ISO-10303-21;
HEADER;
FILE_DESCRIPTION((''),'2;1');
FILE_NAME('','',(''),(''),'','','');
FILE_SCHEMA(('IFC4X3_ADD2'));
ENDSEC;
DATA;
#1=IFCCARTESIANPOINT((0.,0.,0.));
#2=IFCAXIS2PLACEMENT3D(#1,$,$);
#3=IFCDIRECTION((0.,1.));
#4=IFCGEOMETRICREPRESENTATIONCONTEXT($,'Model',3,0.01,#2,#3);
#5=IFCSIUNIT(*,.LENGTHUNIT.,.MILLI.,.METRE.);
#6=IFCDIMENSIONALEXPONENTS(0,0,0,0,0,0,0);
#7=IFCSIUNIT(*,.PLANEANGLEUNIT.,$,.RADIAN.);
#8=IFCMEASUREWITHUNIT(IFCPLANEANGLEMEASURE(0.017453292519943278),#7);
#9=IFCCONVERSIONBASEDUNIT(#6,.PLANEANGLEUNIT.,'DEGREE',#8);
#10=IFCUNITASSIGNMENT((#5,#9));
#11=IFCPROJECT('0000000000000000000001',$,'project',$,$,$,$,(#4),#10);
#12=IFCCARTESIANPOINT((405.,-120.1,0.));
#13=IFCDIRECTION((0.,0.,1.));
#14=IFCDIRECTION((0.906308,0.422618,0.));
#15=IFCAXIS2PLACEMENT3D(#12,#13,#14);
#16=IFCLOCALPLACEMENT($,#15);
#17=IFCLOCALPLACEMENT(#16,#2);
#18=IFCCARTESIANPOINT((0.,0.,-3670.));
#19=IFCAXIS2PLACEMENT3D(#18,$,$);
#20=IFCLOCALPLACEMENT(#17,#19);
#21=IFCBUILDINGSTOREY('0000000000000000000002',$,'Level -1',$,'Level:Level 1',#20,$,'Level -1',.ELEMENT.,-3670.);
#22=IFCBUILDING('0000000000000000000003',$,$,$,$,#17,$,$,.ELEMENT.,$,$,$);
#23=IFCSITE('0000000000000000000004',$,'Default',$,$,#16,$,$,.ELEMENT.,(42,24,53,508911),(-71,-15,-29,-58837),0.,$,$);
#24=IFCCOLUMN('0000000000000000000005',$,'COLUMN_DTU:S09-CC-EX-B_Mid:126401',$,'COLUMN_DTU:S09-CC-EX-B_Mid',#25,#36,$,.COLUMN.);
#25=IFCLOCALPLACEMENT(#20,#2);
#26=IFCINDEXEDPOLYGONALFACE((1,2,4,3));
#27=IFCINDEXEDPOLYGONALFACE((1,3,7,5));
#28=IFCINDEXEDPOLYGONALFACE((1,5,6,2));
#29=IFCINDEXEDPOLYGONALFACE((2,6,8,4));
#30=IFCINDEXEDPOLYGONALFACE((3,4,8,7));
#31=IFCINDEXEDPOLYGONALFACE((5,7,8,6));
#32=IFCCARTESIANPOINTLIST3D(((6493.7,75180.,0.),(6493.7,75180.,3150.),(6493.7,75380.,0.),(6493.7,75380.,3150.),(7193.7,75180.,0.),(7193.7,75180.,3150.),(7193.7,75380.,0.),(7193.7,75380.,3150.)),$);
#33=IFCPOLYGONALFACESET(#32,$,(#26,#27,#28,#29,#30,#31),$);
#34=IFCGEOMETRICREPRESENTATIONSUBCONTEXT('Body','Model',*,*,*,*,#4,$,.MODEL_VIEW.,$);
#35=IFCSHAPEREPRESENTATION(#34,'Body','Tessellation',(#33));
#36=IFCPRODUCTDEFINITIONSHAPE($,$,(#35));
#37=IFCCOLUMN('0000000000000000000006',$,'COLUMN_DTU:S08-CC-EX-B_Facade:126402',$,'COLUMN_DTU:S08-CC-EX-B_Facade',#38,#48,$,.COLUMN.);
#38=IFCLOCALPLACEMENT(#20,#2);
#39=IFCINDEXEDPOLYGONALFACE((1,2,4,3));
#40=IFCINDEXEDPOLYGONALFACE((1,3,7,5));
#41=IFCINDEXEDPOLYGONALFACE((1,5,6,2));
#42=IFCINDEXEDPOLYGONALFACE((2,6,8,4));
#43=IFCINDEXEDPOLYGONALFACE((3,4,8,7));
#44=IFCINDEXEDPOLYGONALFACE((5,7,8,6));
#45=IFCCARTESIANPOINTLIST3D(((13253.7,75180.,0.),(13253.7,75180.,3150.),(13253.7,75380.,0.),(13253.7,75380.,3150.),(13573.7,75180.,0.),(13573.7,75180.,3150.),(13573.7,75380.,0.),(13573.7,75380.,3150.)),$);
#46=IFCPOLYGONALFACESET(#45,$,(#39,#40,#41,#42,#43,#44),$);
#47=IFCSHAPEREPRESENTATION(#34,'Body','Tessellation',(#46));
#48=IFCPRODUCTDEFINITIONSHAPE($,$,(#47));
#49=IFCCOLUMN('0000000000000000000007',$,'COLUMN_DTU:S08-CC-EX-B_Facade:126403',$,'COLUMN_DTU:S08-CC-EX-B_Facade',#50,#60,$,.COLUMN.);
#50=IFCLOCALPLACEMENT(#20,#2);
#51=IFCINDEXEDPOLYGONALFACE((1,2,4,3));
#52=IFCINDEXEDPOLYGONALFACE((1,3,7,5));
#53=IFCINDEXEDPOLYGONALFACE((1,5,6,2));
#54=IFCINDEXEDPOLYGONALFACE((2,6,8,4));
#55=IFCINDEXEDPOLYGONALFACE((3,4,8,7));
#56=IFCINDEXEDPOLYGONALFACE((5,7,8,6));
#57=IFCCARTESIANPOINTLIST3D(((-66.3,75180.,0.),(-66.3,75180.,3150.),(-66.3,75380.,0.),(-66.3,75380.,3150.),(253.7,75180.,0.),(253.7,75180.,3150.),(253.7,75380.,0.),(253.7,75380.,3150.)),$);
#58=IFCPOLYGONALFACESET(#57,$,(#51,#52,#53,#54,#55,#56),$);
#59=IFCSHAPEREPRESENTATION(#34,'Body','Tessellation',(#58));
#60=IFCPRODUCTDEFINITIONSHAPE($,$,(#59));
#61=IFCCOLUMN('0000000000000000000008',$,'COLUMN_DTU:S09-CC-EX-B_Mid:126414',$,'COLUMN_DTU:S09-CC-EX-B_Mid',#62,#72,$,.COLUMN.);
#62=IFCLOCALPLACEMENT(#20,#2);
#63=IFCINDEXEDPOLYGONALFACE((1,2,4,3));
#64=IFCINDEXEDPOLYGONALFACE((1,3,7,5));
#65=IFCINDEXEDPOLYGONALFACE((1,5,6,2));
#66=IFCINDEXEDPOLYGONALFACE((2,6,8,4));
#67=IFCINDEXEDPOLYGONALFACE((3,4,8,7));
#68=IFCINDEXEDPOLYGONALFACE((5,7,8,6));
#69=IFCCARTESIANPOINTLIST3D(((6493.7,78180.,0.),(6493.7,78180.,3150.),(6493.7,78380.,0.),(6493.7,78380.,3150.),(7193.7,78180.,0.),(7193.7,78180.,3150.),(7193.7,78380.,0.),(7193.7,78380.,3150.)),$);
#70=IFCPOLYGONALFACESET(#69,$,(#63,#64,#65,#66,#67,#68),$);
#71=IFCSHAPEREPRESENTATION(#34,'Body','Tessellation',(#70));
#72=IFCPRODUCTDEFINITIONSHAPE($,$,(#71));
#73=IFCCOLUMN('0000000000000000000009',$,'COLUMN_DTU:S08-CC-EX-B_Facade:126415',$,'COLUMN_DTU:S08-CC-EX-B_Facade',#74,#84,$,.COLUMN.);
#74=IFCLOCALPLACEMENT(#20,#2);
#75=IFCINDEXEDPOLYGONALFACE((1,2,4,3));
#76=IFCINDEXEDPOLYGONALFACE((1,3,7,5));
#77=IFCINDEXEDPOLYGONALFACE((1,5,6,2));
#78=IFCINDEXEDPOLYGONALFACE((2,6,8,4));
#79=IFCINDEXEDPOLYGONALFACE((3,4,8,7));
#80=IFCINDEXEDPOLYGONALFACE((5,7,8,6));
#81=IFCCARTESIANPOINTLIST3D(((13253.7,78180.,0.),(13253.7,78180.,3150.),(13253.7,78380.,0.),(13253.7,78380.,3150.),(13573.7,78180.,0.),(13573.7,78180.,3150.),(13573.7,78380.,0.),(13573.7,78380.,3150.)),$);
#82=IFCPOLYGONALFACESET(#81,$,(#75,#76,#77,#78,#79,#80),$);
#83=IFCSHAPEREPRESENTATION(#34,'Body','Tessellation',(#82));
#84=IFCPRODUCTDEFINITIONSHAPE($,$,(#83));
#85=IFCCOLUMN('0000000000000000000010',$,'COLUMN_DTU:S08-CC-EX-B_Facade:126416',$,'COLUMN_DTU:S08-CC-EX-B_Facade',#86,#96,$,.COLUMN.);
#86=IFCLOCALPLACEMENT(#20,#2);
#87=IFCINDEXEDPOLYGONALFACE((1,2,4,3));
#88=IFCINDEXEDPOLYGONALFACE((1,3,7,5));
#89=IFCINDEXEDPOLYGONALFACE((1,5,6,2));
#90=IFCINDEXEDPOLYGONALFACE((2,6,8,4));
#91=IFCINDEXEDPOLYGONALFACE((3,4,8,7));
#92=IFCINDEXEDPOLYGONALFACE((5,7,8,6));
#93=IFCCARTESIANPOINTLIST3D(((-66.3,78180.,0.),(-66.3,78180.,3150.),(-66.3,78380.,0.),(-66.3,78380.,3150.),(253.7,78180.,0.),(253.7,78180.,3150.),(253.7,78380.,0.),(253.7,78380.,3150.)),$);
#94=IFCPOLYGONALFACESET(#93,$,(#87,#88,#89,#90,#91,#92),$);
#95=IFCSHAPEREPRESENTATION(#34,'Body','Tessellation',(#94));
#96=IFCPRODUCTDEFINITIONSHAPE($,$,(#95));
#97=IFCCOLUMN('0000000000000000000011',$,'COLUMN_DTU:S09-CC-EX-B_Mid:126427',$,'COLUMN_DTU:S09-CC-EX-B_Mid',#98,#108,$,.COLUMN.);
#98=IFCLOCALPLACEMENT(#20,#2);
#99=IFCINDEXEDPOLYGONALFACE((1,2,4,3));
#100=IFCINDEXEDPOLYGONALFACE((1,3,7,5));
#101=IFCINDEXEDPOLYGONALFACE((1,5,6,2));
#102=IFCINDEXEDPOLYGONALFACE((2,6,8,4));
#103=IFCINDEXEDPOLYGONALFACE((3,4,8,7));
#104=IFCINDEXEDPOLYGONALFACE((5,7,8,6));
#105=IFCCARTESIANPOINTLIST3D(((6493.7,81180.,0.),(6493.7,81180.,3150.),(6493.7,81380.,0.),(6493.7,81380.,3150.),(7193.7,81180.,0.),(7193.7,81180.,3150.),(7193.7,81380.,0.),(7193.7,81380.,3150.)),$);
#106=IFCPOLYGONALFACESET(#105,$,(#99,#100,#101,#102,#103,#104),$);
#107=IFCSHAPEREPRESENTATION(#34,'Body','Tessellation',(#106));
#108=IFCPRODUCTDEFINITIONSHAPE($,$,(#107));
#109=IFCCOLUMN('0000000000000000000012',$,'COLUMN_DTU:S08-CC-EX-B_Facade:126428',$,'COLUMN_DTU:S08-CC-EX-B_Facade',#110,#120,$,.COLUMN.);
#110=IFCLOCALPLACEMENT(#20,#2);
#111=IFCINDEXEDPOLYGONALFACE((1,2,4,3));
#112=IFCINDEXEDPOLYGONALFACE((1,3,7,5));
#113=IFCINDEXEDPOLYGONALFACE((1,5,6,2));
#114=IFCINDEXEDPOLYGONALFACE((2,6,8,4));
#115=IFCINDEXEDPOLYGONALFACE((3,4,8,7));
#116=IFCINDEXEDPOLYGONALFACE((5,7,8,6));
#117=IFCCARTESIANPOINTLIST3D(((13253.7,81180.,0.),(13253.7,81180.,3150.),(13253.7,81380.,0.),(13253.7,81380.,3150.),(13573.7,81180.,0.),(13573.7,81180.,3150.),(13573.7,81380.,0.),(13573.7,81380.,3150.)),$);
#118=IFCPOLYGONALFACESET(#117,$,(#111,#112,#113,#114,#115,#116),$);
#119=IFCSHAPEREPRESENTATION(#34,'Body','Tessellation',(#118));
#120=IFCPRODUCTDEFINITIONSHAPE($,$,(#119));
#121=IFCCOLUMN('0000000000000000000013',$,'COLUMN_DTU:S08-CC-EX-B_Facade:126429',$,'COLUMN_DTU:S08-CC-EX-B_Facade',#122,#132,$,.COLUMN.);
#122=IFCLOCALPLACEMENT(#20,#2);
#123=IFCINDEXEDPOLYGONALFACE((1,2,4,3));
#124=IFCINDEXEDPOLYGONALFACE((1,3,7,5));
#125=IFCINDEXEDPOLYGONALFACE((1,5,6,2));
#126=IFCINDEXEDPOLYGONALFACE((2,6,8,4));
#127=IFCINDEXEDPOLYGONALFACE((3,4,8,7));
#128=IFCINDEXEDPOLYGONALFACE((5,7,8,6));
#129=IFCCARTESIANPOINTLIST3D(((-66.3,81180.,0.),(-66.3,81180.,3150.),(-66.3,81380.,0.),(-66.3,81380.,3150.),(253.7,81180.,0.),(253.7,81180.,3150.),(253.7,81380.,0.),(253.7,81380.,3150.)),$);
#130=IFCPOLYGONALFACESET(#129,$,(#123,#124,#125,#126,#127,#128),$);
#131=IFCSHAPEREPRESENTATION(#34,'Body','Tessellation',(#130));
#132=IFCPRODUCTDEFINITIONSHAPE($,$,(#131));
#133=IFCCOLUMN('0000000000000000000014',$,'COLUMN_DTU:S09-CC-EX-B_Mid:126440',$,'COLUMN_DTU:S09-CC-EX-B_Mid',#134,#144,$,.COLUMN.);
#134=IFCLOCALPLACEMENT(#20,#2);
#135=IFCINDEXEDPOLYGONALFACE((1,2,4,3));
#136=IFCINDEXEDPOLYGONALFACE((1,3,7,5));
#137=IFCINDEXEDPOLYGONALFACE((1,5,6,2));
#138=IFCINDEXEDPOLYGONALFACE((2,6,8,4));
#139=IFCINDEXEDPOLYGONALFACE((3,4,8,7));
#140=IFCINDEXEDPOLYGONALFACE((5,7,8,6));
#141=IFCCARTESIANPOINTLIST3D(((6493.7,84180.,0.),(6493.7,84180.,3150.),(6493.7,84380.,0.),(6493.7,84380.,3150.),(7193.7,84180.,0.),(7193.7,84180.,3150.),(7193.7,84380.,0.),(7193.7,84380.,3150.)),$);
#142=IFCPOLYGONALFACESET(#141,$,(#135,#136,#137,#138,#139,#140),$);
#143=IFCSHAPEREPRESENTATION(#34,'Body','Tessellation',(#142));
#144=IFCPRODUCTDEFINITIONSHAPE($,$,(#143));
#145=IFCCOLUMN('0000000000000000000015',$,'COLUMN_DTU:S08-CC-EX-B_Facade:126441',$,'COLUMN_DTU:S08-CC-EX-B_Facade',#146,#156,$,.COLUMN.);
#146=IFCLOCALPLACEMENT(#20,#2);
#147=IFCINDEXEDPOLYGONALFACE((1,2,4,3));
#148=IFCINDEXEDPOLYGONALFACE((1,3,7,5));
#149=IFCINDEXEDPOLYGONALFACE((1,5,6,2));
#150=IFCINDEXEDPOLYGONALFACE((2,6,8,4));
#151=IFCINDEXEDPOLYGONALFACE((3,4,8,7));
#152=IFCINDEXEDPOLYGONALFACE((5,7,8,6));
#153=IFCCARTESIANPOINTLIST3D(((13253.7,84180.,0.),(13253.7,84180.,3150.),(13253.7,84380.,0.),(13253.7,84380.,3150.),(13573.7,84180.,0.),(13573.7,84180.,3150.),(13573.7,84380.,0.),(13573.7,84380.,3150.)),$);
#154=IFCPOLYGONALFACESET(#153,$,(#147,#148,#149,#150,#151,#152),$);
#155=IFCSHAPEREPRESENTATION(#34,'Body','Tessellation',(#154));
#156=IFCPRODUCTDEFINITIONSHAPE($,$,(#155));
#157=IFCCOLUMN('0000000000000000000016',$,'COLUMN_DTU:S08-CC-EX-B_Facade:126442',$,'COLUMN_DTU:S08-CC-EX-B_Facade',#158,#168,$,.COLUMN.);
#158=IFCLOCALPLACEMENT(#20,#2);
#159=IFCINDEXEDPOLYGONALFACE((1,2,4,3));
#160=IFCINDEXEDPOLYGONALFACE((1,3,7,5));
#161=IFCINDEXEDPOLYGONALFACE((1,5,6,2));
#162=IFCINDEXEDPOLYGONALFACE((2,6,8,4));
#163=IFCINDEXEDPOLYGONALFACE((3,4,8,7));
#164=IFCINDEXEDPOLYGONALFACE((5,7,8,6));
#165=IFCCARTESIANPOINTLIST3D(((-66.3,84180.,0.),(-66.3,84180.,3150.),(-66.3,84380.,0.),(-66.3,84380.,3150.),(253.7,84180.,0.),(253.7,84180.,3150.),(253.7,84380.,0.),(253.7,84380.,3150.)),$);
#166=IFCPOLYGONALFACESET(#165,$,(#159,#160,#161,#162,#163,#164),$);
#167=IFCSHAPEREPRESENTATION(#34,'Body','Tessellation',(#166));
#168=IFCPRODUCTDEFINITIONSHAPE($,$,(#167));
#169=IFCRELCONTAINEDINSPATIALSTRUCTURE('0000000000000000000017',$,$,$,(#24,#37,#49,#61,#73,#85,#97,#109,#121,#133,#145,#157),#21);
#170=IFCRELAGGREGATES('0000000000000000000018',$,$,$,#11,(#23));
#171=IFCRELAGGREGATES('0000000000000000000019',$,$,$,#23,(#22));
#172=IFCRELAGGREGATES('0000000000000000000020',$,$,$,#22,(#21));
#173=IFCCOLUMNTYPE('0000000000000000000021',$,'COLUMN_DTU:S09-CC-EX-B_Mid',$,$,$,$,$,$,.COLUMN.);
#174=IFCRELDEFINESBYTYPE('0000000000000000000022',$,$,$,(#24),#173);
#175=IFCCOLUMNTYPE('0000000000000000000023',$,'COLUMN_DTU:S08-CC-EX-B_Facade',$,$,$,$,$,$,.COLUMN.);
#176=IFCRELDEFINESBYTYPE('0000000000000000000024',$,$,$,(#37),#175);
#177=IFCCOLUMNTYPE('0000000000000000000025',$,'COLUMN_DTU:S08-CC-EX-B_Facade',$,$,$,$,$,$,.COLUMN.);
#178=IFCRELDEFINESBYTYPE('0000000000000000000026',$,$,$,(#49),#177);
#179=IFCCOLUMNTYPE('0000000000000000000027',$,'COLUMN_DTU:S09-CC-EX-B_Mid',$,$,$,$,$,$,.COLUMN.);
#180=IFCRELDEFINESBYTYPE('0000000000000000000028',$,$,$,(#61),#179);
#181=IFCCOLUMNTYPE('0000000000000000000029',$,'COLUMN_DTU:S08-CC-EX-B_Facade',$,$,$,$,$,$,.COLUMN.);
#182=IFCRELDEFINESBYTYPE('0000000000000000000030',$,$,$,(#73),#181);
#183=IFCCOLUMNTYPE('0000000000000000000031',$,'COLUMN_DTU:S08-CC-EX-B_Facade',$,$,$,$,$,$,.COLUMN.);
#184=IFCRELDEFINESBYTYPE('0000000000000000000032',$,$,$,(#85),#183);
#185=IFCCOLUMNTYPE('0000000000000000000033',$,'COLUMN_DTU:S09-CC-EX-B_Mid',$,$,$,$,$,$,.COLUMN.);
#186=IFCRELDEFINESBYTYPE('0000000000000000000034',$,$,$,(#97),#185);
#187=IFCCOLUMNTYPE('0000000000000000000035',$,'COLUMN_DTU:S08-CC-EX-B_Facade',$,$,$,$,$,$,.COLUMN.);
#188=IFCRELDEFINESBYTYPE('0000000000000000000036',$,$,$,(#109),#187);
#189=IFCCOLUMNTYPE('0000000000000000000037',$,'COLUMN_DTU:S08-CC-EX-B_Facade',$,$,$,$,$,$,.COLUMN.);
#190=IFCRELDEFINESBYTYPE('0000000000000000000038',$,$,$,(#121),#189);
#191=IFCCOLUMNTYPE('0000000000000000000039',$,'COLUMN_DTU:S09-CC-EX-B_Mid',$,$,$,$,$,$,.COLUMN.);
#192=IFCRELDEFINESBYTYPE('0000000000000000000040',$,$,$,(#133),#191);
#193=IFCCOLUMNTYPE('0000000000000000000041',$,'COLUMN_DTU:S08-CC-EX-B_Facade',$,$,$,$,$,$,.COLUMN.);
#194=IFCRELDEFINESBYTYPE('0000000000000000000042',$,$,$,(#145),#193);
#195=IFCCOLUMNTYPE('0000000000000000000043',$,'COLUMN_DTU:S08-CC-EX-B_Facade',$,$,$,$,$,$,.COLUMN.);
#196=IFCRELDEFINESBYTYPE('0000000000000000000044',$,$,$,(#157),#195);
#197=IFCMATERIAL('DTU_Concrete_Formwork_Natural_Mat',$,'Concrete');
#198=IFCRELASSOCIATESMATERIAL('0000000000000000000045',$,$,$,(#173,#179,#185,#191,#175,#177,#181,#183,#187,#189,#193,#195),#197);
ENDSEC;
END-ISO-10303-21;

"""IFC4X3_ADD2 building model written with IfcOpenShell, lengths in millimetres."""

from ifc_helpers import new_model, entity, si_unit, converted_unit, direction, frame, frame_2d, origin, origin_2d_with_axis, place, context, subcontext, project, spatial, rectangle, extrude, source, transform, mapped, material, material_profile, profile_set, type_object, type_shapes, element, save


model = new_model("IFC4X3_ADD2")

# Units and contexts
model_context = context("Model", 3, precision=0.01, world=origin(), true_north=direction((0.0, 1.0)))
body_context = subcontext(model_context, "Body", "Model", "MODEL_VIEW")
ifc_project = project(units=[si_unit("LENGTHUNIT", "METRE", prefix="MILLI"), converted_unit("PLANEANGLEUNIT", "DEGREE", entity("IfcPlaneAngleMeasure", 0.017453292519943278), si_unit("PLANEANGLEUNIT", "RADIAN"), dimensions=[0, 0, 0, 0, 0, 0, 0])], contexts=[model_context])

# Site, building, storey
site_placement = place(None, frame((405.0, -120.1, 0.0), z_axis=(0.0, 0.0, 1.0), x_axis=(0.906308, 0.422618, 0.0)))
site = spatial("IfcSite", under=ifc_project, at=site_placement, Name="Default", CompositionType="ELEMENT", RefLatitude=(42, 24, 53, 508911), RefLongitude=(-71, -15, -29, -58837), RefElevation=0.0)
building_placement = place(site_placement, origin())
building = spatial("IfcBuilding", under=site, at=building_placement, CompositionType="ELEMENT")
storey_placement = place(building_placement, frame((0.0, 0.0, -3670.0)))
storey = spatial("IfcBuildingStorey", under=building, at=storey_placement, Name="Level -1", ObjectType="Level:Level 1", LongName="Level -1", CompositionType="ELEMENT", Elevation=-3670.0)

# Columns
ifc_material = material(Name="DTU_Concrete_Formwork_Natural_Mat", Category="Concrete")
ifc_material_profile_1 = material_profile(ifc_material, rectangle(XDim=200.0, YDim=700.0, at=frame_2d((0.0, 0.0), x_axis=(1.0, 0.0))), Name="S09-CC-EX-B_Mid")
ifc_profile_set_1 = profile_set([ifc_material_profile_1], Name="S09-CC-EX-B_Mid")
column_type_1 = type_object("IfcColumnType", Name="COLUMN_DTU:S09-CC-EX-B_Mid", PredefinedType="COLUMN", material=ifc_profile_set_1)
shared_shape_1 = source(origin(), body_context, "Body", "SweptSolid", [
    extrude(rectangle(XDim=200.0, YDim=700.0, at=frame_2d((0.0, 0.0), x_axis=(1.0, 0.0))), frame((6843.7, 75280.0, -3670.0), z_axis=(0.0, 0.0, 1.0), x_axis=(0.0, 1.0, 0.0)), (0.0, 0.0, 1.0), 3150.0),
])
type_shapes(column_type_1, [shared_shape_1])
column_1_placement = place(storey_placement, frame((0.0, 0.0, 3670.0)))
element("IfcColumn", 1, at=column_1_placement, inside=storey, type_object=column_type_1, Name="COLUMN_DTU:S09-CC-EX-B_Mid:126401", ObjectType="COLUMN_DTU:S09-CC-EX-B_Mid", PredefinedType="COLUMN", context=body_context, shape_type="MappedRepresentation", body=[
    mapped(shared_shape_1, transform((0.0, 0.0, 0.0), scale=1.0)),
])
ifc_material_profile_2 = material_profile(ifc_material, rectangle(XDim=200.0, YDim=320.0, at=origin_2d_with_axis()), Name="S08-CC-EX-B_Facade")
ifc_profile_set_2 = profile_set([ifc_material_profile_2], Name="S08-CC-EX-B_Facade")
column_type_2 = type_object("IfcColumnType", Name="COLUMN_DTU:S08-CC-EX-B_Facade", PredefinedType="COLUMN", material=ifc_profile_set_2)
shared_shape_2 = source(origin(), body_context, "Body", "SweptSolid", [
    extrude(rectangle(XDim=200.0, YDim=320.0, at=frame_2d((0.0, 0.0), x_axis=(1.0, 0.0))), frame((13413.7, 75280.0, -3670.0), z_axis=(0.0, 0.0, 1.0), x_axis=(0.0, 1.0, 0.0)), (0.0, 0.0, 1.0), 3150.0),
])
type_shapes(column_type_2, [shared_shape_2])
column_2_placement = place(storey_placement, frame((0.0, 0.0, 3670.0)))
element("IfcColumn", 2, at=column_2_placement, inside=storey, type_object=column_type_2, Name="COLUMN_DTU:S08-CC-EX-B_Facade:126402", ObjectType="COLUMN_DTU:S08-CC-EX-B_Facade", PredefinedType="COLUMN", context=body_context, shape_type="MappedRepresentation", body=[
    mapped(shared_shape_2, transform((0.0, 0.0, 0.0), scale=1.0)),
])
column_type_3 = type_object("IfcColumnType", Name="COLUMN_DTU:S08-CC-EX-B_Facade", PredefinedType="COLUMN", material=ifc_profile_set_2)
shared_shape_3 = source(origin(), body_context, "Body", "SweptSolid", [
    extrude(rectangle(XDim=200.0, YDim=320.0, at=frame_2d((0.0, 0.0), x_axis=(1.0, 0.0))), frame((93.7, 75280.0, -3670.0), z_axis=(0.0, 0.0, 1.0), x_axis=(0.0, -1.0, 0.0)), (0.0, 0.0, 1.0), 3150.0),
])
type_shapes(column_type_3, [shared_shape_3])
column_3_placement = place(storey_placement, frame((0.0, 0.0, 3670.0)))
element("IfcColumn", 3, at=column_3_placement, inside=storey, type_object=column_type_3, Name="COLUMN_DTU:S08-CC-EX-B_Facade:126403", ObjectType="COLUMN_DTU:S08-CC-EX-B_Facade", PredefinedType="COLUMN", context=body_context, shape_type="MappedRepresentation", body=[
    mapped(shared_shape_3, transform((0.0, 0.0, 0.0), scale=1.0)),
])
column_type_4 = type_object("IfcColumnType", Name="COLUMN_DTU:S09-CC-EX-B_Mid", PredefinedType="COLUMN", material=ifc_profile_set_1)
shared_shape_4 = source(origin(), body_context, "Body", "SweptSolid", [
    extrude(rectangle(XDim=200.0, YDim=700.0, at=frame_2d((0.0, 0.0), x_axis=(1.0, 0.0))), frame((6843.7, 78280.0, -3670.0), z_axis=(0.0, 0.0, 1.0), x_axis=(0.0, 1.0, 0.0)), (0.0, 0.0, 1.0), 3150.0),
])
type_shapes(column_type_4, [shared_shape_4])
column_4_placement = place(storey_placement, frame((0.0, 0.0, 3670.0)))
element("IfcColumn", 4, at=column_4_placement, inside=storey, type_object=column_type_4, Name="COLUMN_DTU:S09-CC-EX-B_Mid:126414", ObjectType="COLUMN_DTU:S09-CC-EX-B_Mid", PredefinedType="COLUMN", context=body_context, shape_type="MappedRepresentation", body=[
    mapped(shared_shape_4, transform((0.0, 0.0, 0.0), scale=1.0)),
])
column_type_5 = type_object("IfcColumnType", Name="COLUMN_DTU:S08-CC-EX-B_Facade", PredefinedType="COLUMN", material=ifc_profile_set_2)
shared_shape_5 = source(origin(), body_context, "Body", "SweptSolid", [
    extrude(rectangle(XDim=200.0, YDim=320.0, at=frame_2d((0.0, 0.0), x_axis=(1.0, 0.0))), frame((13413.7, 78280.0, -3670.0), z_axis=(0.0, 0.0, 1.0), x_axis=(0.0, 1.0, 0.0)), (0.0, 0.0, 1.0), 3150.0),
])
type_shapes(column_type_5, [shared_shape_5])
column_5_placement = place(storey_placement, frame((0.0, 0.0, 3670.0)))
element("IfcColumn", 5, at=column_5_placement, inside=storey, type_object=column_type_5, Name="COLUMN_DTU:S08-CC-EX-B_Facade:126415", ObjectType="COLUMN_DTU:S08-CC-EX-B_Facade", PredefinedType="COLUMN", context=body_context, shape_type="MappedRepresentation", body=[
    mapped(shared_shape_5, transform((0.0, 0.0, 0.0), scale=1.0)),
])
column_type_6 = type_object("IfcColumnType", Name="COLUMN_DTU:S08-CC-EX-B_Facade", PredefinedType="COLUMN", material=ifc_profile_set_2)
shared_shape_6 = source(origin(), body_context, "Body", "SweptSolid", [
    extrude(rectangle(XDim=200.0, YDim=320.0, at=frame_2d((0.0, 0.0), x_axis=(1.0, 0.0))), frame((93.7, 78280.0, -3670.0), z_axis=(0.0, 0.0, 1.0), x_axis=(0.0, -1.0, 0.0)), (0.0, 0.0, 1.0), 3150.0),
])
type_shapes(column_type_6, [shared_shape_6])
column_6_placement = place(storey_placement, frame((0.0, 0.0, 3670.0)))
element("IfcColumn", 6, at=column_6_placement, inside=storey, type_object=column_type_6, Name="COLUMN_DTU:S08-CC-EX-B_Facade:126416", ObjectType="COLUMN_DTU:S08-CC-EX-B_Facade", PredefinedType="COLUMN", context=body_context, shape_type="MappedRepresentation", body=[
    mapped(shared_shape_6, transform((0.0, 0.0, 0.0), scale=1.0)),
])
column_type_7 = type_object("IfcColumnType", Name="COLUMN_DTU:S09-CC-EX-B_Mid", PredefinedType="COLUMN", material=ifc_profile_set_1)
shared_shape_7 = source(origin(), body_context, "Body", "SweptSolid", [
    extrude(rectangle(XDim=200.0, YDim=700.0, at=frame_2d((0.0, 0.0), x_axis=(1.0, 0.0))), frame((6843.7, 81280.0, -3670.0), z_axis=(0.0, 0.0, 1.0), x_axis=(0.0, 1.0, 0.0)), (0.0, 0.0, 1.0), 3150.0),
])
type_shapes(column_type_7, [shared_shape_7])
column_7_placement = place(storey_placement, frame((0.0, 0.0, 3670.0)))
element("IfcColumn", 7, at=column_7_placement, inside=storey, type_object=column_type_7, Name="COLUMN_DTU:S09-CC-EX-B_Mid:126427", ObjectType="COLUMN_DTU:S09-CC-EX-B_Mid", PredefinedType="COLUMN", context=body_context, shape_type="MappedRepresentation", body=[
    mapped(shared_shape_7, transform((0.0, 0.0, 0.0), scale=1.0)),
])
column_type_8 = type_object("IfcColumnType", Name="COLUMN_DTU:S08-CC-EX-B_Facade", PredefinedType="COLUMN", material=ifc_profile_set_2)
shared_shape_8 = source(origin(), body_context, "Body", "SweptSolid", [
    extrude(rectangle(XDim=200.0, YDim=320.0, at=frame_2d((0.0, 0.0), x_axis=(1.0, 0.0))), frame((13413.7, 81280.0, -3670.0), z_axis=(0.0, 0.0, 1.0), x_axis=(0.0, 1.0, 0.0)), (0.0, 0.0, 1.0), 3150.0),
])
type_shapes(column_type_8, [shared_shape_8])
column_8_placement = place(storey_placement, frame((0.0, 0.0, 3670.0)))
element("IfcColumn", 8, at=column_8_placement, inside=storey, type_object=column_type_8, Name="COLUMN_DTU:S08-CC-EX-B_Facade:126428", ObjectType="COLUMN_DTU:S08-CC-EX-B_Facade", PredefinedType="COLUMN", context=body_context, shape_type="MappedRepresentation", body=[
    mapped(shared_shape_8, transform((0.0, 0.0, 0.0), scale=1.0)),
])
column_type_9 = type_object("IfcColumnType", Name="COLUMN_DTU:S08-CC-EX-B_Facade", PredefinedType="COLUMN", material=ifc_profile_set_2)
shared_shape_9 = source(origin(), body_context, "Body", "SweptSolid", [
    extrude(rectangle(XDim=200.0, YDim=320.0, at=frame_2d((0.0, 0.0), x_axis=(1.0, 0.0))), frame((93.7, 81280.0, -3670.0), z_axis=(0.0, 0.0, 1.0), x_axis=(0.0, -1.0, 0.0)), (0.0, 0.0, 1.0), 3150.0),
])
type_shapes(column_type_9, [shared_shape_9])
column_9_placement = place(storey_placement, frame((0.0, 0.0, 3670.0)))
element("IfcColumn", 9, at=column_9_placement, inside=storey, type_object=column_type_9, Name="COLUMN_DTU:S08-CC-EX-B_Facade:126429", ObjectType="COLUMN_DTU:S08-CC-EX-B_Facade", PredefinedType="COLUMN", context=body_context, shape_type="MappedRepresentation", body=[
    mapped(shared_shape_9, transform((0.0, 0.0, 0.0), scale=1.0)),
])
column_type_10 = type_object("IfcColumnType", Name="COLUMN_DTU:S09-CC-EX-B_Mid", PredefinedType="COLUMN", material=ifc_profile_set_1)
shared_shape_10 = source(origin(), body_context, "Body", "SweptSolid", [
    extrude(rectangle(XDim=200.0, YDim=700.0, at=frame_2d((0.0, 0.0), x_axis=(1.0, 0.0))), frame((6843.7, 84280.0, -3670.0), z_axis=(0.0, 0.0, 1.0), x_axis=(0.0, 1.0, 0.0)), (0.0, 0.0, 1.0), 3150.0),
])
type_shapes(column_type_10, [shared_shape_10])
column_10_placement = place(storey_placement, frame((0.0, 0.0, 3670.0)))
element("IfcColumn", 10, at=column_10_placement, inside=storey, type_object=column_type_10, Name="COLUMN_DTU:S09-CC-EX-B_Mid:126440", ObjectType="COLUMN_DTU:S09-CC-EX-B_Mid", PredefinedType="COLUMN", context=body_context, shape_type="MappedRepresentation", body=[
    mapped(shared_shape_10, transform((0.0, 0.0, 0.0), scale=1.0)),
])
column_type_11 = type_object("IfcColumnType", Name="COLUMN_DTU:S08-CC-EX-B_Facade", PredefinedType="COLUMN", material=ifc_profile_set_2)
shared_shape_11 = source(origin(), body_context, "Body", "SweptSolid", [
    extrude(rectangle(XDim=200.0, YDim=320.0, at=frame_2d((0.0, 0.0), x_axis=(1.0, 0.0))), frame((13413.7, 84280.0, -3670.0), z_axis=(0.0, 0.0, 1.0), x_axis=(0.0, 1.0, 0.0)), (0.0, 0.0, 1.0), 3150.0),
])
type_shapes(column_type_11, [shared_shape_11])
column_11_placement = place(storey_placement, frame((0.0, 0.0, 3670.0)))
element("IfcColumn", 11, at=column_11_placement, inside=storey, type_object=column_type_11, Name="COLUMN_DTU:S08-CC-EX-B_Facade:126441", ObjectType="COLUMN_DTU:S08-CC-EX-B_Facade", PredefinedType="COLUMN", context=body_context, shape_type="MappedRepresentation", body=[
    mapped(shared_shape_11, transform((0.0, 0.0, 0.0), scale=1.0)),
])
column_type_12 = type_object("IfcColumnType", Name="COLUMN_DTU:S08-CC-EX-B_Facade", PredefinedType="COLUMN", material=ifc_profile_set_2)
shared_shape_12 = source(origin(), body_context, "Body", "SweptSolid", [
    extrude(rectangle(XDim=200.0, YDim=320.0, at=frame_2d((0.0, 0.0), x_axis=(1.0, 0.0))), frame((93.7, 84280.0, -3670.0), z_axis=(0.0, 0.0, 1.0), x_axis=(0.0, -1.0, 0.0)), (0.0, 0.0, 1.0), 3150.0),
])
type_shapes(column_type_12, [shared_shape_12])
column_12_placement = place(storey_placement, frame((0.0, 0.0, 3670.0)))
element("IfcColumn", 12, at=column_12_placement, inside=storey, type_object=column_type_12, Name="COLUMN_DTU:S08-CC-EX-B_Facade:126442", ObjectType="COLUMN_DTU:S08-CC-EX-B_Facade", PredefinedType="COLUMN", context=body_context, shape_type="MappedRepresentation", body=[
    mapped(shared_shape_12, transform((0.0, 0.0, 0.0), scale=1.0)),
])

save(model, "model.ifc")
